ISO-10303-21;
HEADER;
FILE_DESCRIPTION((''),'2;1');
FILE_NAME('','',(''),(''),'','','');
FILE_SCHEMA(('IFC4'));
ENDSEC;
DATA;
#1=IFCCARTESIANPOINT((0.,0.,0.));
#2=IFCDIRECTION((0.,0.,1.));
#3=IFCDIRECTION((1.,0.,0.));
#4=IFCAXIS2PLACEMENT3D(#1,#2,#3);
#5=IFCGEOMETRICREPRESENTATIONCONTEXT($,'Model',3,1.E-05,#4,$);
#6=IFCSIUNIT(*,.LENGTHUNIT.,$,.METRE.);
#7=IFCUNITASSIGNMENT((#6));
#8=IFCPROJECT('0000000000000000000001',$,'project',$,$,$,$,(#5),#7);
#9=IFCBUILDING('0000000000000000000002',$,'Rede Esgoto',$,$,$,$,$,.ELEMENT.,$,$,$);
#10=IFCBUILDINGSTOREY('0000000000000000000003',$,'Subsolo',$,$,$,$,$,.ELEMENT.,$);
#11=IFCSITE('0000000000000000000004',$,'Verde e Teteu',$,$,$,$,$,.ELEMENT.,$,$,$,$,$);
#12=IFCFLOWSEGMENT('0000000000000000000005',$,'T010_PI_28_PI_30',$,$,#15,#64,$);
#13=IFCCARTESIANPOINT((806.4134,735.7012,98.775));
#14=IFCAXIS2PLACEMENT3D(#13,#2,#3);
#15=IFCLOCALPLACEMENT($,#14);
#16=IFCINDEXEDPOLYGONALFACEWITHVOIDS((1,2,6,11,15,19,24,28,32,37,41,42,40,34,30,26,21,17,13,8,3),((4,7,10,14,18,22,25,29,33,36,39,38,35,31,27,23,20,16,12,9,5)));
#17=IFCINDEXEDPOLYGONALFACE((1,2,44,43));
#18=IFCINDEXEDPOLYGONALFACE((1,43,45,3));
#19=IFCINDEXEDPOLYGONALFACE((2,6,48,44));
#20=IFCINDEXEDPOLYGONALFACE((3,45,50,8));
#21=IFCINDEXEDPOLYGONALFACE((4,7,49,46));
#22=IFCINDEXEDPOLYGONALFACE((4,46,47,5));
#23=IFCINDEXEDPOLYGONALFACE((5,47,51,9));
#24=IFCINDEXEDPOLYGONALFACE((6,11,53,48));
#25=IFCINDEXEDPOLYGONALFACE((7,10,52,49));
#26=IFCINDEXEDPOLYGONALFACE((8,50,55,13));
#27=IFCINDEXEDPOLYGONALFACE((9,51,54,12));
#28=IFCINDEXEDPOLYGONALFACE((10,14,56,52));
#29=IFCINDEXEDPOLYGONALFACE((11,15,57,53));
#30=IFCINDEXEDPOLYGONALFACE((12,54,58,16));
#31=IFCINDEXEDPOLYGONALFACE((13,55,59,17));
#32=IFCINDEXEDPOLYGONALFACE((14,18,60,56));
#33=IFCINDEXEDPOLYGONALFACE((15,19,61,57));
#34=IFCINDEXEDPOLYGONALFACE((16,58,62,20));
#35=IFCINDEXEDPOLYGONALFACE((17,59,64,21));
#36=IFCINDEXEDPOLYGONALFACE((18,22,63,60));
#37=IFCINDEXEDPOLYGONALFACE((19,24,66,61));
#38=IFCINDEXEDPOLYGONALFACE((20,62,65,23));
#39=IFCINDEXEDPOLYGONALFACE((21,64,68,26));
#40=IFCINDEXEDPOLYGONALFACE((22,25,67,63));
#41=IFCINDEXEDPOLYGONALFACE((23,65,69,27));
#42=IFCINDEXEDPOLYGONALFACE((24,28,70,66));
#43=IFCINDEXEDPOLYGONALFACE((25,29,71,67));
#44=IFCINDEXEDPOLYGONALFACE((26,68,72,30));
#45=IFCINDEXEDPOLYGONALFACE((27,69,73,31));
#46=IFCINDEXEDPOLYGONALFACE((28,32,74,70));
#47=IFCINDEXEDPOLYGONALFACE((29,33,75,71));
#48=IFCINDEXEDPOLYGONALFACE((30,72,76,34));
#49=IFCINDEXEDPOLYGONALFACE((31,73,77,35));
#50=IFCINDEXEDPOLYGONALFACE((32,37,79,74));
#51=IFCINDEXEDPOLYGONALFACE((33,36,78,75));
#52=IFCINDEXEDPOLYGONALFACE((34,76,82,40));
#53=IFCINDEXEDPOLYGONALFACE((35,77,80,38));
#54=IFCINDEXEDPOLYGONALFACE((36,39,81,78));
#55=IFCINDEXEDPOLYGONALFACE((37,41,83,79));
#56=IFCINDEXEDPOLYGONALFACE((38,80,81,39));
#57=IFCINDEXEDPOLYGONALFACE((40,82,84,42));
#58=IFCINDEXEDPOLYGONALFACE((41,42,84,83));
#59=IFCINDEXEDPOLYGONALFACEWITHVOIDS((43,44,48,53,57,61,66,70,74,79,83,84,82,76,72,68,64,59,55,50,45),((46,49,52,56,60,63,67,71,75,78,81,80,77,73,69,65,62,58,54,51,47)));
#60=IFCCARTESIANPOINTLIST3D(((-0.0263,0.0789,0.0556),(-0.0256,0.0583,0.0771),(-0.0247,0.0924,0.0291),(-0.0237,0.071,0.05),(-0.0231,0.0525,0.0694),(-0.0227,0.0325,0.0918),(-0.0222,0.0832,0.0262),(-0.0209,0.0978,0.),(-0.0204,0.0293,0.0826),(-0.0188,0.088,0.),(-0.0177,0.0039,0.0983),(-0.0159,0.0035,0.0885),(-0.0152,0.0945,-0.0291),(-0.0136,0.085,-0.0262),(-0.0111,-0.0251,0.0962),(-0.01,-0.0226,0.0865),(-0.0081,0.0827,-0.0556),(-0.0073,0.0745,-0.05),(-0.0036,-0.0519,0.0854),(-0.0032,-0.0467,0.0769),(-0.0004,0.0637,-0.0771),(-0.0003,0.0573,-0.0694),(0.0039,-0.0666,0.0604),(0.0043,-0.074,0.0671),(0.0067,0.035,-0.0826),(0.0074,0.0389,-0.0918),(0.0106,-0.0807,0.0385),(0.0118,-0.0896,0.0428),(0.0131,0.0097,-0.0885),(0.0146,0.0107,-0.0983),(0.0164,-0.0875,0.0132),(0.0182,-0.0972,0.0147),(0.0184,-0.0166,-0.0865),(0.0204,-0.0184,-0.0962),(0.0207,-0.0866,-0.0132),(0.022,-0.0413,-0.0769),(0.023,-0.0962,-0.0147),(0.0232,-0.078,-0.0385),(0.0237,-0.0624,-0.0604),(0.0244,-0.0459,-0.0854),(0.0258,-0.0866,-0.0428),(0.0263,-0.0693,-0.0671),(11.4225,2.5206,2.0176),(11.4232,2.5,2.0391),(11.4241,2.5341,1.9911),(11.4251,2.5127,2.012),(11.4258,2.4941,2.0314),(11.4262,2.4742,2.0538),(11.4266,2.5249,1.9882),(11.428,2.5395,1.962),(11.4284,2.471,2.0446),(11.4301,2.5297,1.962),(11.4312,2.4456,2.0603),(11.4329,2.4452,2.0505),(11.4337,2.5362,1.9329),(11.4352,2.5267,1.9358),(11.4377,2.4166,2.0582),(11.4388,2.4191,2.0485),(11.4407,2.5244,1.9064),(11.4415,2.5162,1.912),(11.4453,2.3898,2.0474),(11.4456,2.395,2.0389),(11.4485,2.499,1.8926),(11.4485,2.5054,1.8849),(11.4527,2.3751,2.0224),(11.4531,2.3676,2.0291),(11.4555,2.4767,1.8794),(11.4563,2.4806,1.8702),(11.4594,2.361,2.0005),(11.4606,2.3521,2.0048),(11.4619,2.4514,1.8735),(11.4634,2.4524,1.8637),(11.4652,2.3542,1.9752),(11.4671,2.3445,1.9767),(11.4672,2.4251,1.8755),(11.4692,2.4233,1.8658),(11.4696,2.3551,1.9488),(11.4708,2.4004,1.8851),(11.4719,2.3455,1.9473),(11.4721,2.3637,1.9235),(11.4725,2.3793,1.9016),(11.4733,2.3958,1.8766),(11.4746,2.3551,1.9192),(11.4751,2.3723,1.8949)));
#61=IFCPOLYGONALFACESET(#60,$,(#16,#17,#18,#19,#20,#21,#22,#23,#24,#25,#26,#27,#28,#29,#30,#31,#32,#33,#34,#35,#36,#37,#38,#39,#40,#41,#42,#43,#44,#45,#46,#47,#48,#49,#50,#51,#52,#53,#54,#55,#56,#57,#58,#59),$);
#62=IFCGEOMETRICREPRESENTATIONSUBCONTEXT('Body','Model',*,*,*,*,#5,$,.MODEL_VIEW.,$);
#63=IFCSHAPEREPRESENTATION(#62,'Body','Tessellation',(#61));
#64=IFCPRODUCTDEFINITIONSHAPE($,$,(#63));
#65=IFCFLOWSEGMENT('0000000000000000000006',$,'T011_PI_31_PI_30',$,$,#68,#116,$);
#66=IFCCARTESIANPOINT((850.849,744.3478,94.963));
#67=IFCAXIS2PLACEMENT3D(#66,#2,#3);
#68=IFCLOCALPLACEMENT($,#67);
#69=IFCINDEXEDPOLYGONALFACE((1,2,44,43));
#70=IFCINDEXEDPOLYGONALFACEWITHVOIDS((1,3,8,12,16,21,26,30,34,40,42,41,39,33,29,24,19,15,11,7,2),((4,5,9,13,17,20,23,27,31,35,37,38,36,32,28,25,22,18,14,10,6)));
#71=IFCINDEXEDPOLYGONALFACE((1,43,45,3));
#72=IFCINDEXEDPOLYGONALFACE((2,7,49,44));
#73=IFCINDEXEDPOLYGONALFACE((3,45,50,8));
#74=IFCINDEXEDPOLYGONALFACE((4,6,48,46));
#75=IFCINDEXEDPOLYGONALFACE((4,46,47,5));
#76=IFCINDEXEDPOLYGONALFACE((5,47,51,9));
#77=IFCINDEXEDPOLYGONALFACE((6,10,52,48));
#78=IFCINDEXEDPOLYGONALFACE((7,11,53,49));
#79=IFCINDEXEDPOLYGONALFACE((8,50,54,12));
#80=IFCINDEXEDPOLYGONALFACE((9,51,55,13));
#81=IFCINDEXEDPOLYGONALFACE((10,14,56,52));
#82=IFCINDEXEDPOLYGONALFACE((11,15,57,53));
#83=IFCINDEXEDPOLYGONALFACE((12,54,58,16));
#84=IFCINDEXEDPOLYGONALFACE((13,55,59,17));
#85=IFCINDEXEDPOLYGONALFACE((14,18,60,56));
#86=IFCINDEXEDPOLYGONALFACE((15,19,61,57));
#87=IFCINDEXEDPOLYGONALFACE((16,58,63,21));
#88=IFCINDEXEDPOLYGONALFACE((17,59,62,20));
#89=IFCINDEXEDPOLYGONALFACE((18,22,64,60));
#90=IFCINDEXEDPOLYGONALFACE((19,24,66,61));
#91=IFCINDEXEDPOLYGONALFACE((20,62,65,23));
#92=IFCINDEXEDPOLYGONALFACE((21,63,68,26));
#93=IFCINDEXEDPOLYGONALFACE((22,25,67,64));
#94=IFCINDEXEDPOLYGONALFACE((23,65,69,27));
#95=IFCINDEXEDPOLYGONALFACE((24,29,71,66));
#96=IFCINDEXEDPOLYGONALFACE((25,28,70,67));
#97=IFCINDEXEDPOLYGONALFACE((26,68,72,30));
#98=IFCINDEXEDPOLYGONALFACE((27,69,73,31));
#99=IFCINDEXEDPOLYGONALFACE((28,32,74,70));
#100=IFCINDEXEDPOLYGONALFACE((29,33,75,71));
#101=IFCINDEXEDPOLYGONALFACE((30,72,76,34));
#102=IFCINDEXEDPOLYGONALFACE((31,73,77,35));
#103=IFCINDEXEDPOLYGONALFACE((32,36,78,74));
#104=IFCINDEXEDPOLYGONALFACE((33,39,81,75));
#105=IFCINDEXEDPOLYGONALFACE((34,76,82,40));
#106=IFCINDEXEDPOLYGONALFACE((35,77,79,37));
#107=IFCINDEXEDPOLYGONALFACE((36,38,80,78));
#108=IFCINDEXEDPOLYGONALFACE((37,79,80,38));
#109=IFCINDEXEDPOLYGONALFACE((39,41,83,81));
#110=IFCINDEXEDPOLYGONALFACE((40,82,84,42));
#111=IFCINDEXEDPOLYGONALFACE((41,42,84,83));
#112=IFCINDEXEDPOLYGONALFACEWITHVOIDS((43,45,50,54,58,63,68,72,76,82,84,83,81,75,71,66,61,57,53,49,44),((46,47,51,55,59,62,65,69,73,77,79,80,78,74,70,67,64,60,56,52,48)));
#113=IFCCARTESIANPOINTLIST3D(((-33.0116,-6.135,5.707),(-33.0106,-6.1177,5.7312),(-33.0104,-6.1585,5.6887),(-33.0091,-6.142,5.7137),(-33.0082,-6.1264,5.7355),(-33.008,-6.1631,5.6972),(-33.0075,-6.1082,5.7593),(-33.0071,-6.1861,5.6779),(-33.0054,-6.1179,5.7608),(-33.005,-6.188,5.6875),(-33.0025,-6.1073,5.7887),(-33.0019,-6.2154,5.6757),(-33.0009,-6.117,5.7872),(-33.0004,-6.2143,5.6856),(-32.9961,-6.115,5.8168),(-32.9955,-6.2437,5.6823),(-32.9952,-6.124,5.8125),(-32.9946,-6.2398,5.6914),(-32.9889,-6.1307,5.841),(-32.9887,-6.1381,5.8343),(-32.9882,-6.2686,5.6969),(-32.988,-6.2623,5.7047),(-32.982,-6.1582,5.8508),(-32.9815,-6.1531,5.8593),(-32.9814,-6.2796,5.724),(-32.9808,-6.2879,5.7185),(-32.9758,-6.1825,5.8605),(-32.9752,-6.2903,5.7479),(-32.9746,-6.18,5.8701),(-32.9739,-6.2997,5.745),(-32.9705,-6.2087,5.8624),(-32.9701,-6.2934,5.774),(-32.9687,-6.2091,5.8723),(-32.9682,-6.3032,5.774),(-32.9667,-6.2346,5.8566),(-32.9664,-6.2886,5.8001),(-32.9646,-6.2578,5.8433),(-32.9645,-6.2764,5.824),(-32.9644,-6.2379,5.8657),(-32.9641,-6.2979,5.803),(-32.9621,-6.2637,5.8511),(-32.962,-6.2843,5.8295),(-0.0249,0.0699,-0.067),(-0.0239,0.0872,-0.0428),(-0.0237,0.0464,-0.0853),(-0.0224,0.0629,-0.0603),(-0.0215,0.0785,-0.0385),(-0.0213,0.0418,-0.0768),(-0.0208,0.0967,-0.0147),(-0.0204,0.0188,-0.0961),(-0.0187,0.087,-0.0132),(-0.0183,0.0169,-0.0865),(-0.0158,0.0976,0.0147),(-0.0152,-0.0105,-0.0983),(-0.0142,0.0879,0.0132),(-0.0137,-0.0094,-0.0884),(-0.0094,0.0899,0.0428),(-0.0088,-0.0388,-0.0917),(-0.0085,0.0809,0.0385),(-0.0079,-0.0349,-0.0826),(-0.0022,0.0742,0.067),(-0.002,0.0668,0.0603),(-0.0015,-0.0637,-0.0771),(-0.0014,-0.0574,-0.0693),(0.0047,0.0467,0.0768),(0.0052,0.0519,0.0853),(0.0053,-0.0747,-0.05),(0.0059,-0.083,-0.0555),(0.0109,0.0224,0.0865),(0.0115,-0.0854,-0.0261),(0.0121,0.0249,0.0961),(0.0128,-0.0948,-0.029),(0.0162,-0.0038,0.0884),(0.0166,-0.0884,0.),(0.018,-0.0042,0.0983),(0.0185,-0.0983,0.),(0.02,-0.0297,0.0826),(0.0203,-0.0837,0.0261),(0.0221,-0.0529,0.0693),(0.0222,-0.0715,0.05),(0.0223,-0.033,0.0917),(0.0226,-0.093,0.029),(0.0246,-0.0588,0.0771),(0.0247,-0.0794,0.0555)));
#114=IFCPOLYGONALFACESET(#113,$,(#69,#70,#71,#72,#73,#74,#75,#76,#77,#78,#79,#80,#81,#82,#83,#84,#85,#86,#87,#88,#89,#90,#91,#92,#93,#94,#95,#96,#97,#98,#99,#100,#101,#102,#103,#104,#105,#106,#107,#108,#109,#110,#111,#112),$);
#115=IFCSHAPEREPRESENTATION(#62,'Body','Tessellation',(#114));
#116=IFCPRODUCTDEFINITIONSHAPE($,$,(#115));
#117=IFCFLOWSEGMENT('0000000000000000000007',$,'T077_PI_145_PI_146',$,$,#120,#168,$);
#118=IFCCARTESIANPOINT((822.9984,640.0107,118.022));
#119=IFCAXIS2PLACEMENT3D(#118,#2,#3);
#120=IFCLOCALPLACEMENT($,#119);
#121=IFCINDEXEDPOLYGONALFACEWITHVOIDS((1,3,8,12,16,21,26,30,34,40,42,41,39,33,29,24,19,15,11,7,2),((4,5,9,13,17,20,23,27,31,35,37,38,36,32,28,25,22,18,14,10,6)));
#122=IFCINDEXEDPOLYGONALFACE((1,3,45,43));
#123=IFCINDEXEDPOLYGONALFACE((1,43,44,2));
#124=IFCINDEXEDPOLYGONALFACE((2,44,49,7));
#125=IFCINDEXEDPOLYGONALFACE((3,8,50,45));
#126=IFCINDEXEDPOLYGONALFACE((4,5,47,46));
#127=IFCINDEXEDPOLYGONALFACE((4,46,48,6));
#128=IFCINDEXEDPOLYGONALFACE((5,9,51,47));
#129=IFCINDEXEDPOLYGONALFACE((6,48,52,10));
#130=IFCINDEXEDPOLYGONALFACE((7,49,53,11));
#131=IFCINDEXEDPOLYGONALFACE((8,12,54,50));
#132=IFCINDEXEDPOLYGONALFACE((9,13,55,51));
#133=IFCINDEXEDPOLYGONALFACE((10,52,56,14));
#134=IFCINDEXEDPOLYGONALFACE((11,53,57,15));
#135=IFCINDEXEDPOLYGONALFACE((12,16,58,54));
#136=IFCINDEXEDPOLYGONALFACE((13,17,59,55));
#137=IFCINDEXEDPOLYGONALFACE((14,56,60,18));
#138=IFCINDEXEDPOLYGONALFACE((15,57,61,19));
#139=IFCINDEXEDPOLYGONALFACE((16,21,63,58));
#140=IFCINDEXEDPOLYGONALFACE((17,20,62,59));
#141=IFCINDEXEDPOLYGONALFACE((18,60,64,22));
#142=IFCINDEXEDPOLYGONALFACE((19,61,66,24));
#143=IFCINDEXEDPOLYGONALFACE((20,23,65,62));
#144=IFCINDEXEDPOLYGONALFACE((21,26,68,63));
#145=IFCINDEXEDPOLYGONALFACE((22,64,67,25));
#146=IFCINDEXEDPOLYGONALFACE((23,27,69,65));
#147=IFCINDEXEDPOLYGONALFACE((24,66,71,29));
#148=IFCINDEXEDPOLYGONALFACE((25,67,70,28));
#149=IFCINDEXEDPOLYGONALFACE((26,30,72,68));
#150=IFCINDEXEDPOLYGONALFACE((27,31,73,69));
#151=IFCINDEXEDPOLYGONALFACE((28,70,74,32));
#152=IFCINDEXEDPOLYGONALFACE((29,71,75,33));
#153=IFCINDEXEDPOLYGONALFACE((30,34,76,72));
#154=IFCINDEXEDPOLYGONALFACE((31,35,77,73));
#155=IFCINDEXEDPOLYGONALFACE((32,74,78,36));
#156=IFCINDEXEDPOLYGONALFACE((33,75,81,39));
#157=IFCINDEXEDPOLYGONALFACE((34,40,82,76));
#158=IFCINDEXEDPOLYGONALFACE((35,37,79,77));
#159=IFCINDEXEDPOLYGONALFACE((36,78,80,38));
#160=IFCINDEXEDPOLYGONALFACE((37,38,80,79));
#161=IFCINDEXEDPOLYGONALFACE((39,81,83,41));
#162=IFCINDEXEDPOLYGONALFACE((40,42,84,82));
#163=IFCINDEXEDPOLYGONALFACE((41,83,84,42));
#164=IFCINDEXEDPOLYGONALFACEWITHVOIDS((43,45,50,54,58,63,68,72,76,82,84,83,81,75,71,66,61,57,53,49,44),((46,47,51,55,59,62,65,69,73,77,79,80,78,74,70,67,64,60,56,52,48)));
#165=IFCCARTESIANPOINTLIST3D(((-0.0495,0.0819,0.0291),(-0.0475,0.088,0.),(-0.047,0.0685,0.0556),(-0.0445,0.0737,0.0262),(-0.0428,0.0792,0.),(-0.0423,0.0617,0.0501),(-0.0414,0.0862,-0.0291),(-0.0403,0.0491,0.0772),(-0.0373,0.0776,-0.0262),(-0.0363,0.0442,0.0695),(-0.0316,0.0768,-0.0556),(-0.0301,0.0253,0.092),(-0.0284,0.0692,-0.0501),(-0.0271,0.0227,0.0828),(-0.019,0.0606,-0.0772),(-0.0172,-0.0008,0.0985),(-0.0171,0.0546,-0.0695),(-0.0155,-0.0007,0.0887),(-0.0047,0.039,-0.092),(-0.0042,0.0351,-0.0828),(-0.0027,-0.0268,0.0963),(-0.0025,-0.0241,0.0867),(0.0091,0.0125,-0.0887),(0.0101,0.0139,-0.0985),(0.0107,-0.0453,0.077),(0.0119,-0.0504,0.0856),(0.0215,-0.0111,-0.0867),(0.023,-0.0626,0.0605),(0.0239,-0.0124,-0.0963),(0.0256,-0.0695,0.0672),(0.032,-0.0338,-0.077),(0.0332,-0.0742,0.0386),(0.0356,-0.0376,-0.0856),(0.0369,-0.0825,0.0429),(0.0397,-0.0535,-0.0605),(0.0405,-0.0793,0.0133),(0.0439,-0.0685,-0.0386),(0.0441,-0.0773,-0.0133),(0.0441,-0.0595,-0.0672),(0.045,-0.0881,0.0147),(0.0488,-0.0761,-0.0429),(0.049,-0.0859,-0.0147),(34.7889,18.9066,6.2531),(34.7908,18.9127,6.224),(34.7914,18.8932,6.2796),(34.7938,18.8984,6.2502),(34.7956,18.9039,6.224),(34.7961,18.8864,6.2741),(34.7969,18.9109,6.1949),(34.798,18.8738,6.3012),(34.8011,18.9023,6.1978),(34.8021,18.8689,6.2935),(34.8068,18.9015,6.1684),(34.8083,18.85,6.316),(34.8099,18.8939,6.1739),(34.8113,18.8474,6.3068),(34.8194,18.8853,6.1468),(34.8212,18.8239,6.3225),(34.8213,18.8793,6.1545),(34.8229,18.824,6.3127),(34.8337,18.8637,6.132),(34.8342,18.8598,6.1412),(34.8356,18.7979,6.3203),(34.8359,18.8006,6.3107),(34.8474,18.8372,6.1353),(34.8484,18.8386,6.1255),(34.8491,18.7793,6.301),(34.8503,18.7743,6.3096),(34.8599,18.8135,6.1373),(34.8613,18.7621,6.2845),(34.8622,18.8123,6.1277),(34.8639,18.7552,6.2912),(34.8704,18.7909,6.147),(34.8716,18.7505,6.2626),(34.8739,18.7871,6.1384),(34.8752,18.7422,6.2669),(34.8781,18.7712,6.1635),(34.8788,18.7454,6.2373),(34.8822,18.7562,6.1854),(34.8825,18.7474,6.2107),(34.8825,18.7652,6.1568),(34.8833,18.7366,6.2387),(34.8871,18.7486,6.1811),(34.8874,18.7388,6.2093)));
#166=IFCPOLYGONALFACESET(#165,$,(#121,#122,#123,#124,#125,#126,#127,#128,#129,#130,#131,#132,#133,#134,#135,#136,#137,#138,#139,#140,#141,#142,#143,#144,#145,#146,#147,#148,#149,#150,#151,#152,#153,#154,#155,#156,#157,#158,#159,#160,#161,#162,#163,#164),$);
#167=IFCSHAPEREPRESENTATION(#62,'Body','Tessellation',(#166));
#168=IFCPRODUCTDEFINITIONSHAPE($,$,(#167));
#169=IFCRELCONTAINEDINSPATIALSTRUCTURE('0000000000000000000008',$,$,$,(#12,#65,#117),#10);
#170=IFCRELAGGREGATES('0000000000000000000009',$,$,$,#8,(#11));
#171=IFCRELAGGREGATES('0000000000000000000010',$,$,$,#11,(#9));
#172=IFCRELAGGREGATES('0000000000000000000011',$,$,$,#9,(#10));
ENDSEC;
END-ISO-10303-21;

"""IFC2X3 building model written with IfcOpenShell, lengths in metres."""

from ifc_helpers import new_model, entity, si_unit, frame, origin_with_axes, place, context, subcontext, project, spatial, element, save


model = new_model("IFC2X3")

# Units and contexts
model_context = context("Model", 3, precision=1e-05, world=origin_with_axes())
body_context = subcontext(model_context, "Body", "Model", "MODEL_VIEW")
ifc_project = project(units=[si_unit("LENGTHUNIT", "METRE")], contexts=[model_context])

# Site, building, storey
site = spatial("IfcSite", under=ifc_project, Name="Verde e Teteu", CompositionType="ELEMENT")
building = spatial("IfcBuilding", under=site, Name="Rede Esgoto", CompositionType="ELEMENT")
storey = spatial("IfcBuildingStorey", under=building, Name="Subsolo", CompositionType="ELEMENT")

# Flow segments
flow_segment_1_placement = place(None, frame((806.4134, 735.7012, 98.775), z_axis=(0.0, 0.0, 1.0), x_axis=(1.0, 0.0, 0.0)))
element("IfcFlowSegment", 1, at=flow_segment_1_placement, inside=storey, Name="T010_PI_28_PI_30", context=body_context, shape_type="SweptSolid", body=[
    entity("IfcSweptDiskSolid", entity("IfcPolyline", [entity("IfcCartesianPoint", [0.0, 0.0, 0.0]), entity("IfcCartesianPoint", [11.4488, 2.4417, 1.962])]), 0.1, 0.09),
])
flow_segment_2_placement = place(None, frame((850.849, 744.3478, 94.963), z_axis=(0.0, 0.0, 1.0), x_axis=(1.0, 0.0, 0.0)))
element("IfcFlowSegment", 2, at=flow_segment_2_placement, inside=storey, Name="T011_PI_31_PI_30", context=body_context, shape_type="SweptSolid", body=[
    entity("IfcSweptDiskSolid", entity("IfcPolyline", [entity("IfcCartesianPoint", [0.0, 0.0, 0.0]), entity("IfcCartesianPoint", [-32.9867, -6.2049, 5.774])]), 0.1, 0.09),
])
flow_segment_3_placement = place(None, frame((822.9984, 640.0107, 118.022), z_axis=(0.0, 0.0, 1.0), x_axis=(1.0, 0.0, 0.0)))
element("IfcFlowSegment", 3, at=flow_segment_3_placement, inside=storey, Name="T077_PI_145_PI_146", context=body_context, shape_type="SweptSolid", body=[
    entity("IfcSweptDiskSolid", entity("IfcPolyline", [entity("IfcCartesianPoint", [0.0, 0.0, 0.0]), entity("IfcCartesianPoint", [34.8383, 18.8247, 6.224])]), 0.1, 0.09),
])

save(model, "model.ifc")
